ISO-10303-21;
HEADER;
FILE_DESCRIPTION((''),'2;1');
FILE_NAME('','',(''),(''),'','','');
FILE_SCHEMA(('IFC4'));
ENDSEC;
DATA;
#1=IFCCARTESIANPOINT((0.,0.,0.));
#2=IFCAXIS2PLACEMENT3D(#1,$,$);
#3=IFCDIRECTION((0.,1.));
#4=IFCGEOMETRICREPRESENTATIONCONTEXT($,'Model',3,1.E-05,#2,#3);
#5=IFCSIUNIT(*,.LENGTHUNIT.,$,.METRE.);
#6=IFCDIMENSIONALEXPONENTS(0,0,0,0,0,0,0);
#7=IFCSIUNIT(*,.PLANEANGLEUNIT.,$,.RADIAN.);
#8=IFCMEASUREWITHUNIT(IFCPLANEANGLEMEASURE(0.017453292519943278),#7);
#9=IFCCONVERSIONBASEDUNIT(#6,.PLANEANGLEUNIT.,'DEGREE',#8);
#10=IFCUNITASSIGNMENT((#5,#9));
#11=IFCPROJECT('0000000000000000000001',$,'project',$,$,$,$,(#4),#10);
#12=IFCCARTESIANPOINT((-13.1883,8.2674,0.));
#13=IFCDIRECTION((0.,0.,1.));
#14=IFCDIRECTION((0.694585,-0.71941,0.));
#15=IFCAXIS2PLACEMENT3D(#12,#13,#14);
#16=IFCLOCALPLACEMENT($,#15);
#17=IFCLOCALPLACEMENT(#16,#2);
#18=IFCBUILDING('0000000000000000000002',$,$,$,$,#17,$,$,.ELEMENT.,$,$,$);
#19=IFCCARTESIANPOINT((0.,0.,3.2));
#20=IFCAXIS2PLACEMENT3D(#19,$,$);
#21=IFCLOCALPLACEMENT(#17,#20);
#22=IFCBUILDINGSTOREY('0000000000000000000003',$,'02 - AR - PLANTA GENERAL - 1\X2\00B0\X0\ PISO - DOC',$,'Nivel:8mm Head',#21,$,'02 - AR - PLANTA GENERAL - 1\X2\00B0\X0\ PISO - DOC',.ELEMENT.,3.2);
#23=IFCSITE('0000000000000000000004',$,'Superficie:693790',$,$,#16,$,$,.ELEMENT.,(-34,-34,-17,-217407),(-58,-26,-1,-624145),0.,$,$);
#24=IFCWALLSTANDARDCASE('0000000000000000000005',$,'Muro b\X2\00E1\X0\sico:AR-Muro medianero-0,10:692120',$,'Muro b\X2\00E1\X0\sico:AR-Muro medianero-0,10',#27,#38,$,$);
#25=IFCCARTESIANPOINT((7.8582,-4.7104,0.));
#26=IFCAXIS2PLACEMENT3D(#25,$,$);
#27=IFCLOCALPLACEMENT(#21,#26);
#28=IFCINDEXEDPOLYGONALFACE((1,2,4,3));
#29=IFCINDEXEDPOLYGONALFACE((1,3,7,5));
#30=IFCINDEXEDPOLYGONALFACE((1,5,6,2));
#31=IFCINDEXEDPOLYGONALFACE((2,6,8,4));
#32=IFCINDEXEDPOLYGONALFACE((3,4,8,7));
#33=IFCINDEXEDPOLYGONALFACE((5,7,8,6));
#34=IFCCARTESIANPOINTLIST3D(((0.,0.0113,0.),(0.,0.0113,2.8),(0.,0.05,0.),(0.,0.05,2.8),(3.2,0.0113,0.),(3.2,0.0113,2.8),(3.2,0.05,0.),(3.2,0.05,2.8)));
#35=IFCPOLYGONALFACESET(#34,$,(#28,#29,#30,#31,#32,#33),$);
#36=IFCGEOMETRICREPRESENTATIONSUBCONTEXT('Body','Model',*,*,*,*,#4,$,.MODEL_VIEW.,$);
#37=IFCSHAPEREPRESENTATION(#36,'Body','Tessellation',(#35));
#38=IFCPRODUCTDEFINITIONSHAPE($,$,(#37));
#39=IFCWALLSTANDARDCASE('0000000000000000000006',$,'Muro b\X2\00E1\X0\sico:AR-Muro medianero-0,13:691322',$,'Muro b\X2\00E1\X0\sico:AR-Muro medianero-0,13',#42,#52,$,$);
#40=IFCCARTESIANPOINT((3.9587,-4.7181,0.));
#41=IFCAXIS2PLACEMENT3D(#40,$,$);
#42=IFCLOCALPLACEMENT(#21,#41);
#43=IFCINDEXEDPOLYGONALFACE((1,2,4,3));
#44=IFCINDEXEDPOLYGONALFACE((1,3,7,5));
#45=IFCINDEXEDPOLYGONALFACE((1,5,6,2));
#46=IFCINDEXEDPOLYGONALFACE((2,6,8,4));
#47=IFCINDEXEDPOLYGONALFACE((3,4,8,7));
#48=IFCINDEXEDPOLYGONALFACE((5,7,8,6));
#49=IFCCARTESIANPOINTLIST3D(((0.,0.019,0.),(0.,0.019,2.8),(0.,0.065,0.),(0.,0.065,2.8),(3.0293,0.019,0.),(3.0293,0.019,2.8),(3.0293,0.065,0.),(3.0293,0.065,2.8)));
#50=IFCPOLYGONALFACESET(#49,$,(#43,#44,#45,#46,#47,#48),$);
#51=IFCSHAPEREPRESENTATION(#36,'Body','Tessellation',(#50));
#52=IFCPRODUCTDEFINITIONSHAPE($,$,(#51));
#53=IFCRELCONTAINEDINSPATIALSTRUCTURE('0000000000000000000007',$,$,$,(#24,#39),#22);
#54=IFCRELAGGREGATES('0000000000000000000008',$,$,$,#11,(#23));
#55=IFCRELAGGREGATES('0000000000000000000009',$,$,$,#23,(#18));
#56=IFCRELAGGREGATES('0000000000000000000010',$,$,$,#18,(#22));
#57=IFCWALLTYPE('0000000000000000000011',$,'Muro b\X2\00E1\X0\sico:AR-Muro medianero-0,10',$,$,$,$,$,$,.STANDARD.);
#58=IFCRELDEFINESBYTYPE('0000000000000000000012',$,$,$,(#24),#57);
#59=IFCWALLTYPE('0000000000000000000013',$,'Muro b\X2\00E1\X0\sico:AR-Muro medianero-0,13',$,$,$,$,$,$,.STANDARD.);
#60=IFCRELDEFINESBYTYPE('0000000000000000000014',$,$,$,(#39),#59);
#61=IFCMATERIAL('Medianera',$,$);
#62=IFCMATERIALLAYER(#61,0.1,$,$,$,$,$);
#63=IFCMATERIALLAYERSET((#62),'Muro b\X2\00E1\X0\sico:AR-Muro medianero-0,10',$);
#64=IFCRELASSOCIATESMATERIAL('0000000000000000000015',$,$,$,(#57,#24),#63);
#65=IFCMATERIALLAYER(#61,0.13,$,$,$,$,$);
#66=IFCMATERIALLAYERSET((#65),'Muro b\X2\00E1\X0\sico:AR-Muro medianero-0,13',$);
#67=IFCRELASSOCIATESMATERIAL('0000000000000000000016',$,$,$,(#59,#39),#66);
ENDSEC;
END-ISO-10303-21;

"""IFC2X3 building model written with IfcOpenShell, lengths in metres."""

from ifc_helpers import new_model, entity, si_unit, converted_unit, direction, frame, frame_2d, origin, place, context, subcontext, project, spatial, polyline, rectangle, extrude, clip, bounded_halfspace, material, layer, layer_set, layer_usage, type_object, element, save


model = new_model("IFC2X3")

# Units and contexts
model_context = context("Model", 3, precision=1e-05, world=origin(), true_north=direction((0.0, 1.0)))
body_context = subcontext(model_context, "Body", "Model", "MODEL_VIEW")
ifc_project = project(units=[si_unit("LENGTHUNIT", "METRE"), converted_unit("PLANEANGLEUNIT", "DEGREE", entity("IfcPlaneAngleMeasure", 0.017453292519943278), si_unit("PLANEANGLEUNIT", "RADIAN"), dimensions=[0, 0, 0, 0, 0, 0, 0])], contexts=[model_context])

# Site, building, storey
site_placement = place(None, frame((-13.1883, 8.2674, 0.0), z_axis=(0.0, 0.0, 1.0), x_axis=(0.694585, -0.71941, 0.0)))
site = spatial("IfcSite", under=ifc_project, at=site_placement, Name="Superficie:693790", CompositionType="ELEMENT", RefLatitude=(-34, -34, -17, -217407), RefLongitude=(-58, -26, -1, -624145), RefElevation=0.0)
building_placement = place(site_placement, origin())
building = spatial("IfcBuilding", under=site, at=building_placement, CompositionType="ELEMENT")
storey_placement = place(building_placement, frame((0.0, 0.0, 3.2)))
storey = spatial("IfcBuildingStorey", under=building, at=storey_placement, Name="02 - AR - PLANTA GENERAL - 1° PISO - DOC", ObjectType="Nivel:8mm Head", LongName="02 - AR - PLANTA GENERAL - 1° PISO - DOC", CompositionType="ELEMENT", Elevation=3.2)

# Walls
ifc_material_1 = material(Name="Medianera")
ifc_layer_1 = layer(ifc_material_1, 0.1)
ifc_layer_set_1 = layer_set([ifc_layer_1], Name="Muro básico:AR-Muro medianero-0,10")
ifc_layer_usage_1 = layer_usage(ifc_layer_set_1, "AXIS2", "NEGATIVE", 0.05)
wall_type_1 = type_object("IfcWallType", Name="Muro básico:AR-Muro medianero-0,10", PredefinedType="STANDARD", material=ifc_layer_set_1)
wall_1_placement = place(storey_placement, frame((7.8582, -4.7104, 0.0)))
element("IfcWallStandardCase", 1, at=wall_1_placement, inside=storey, type_object=wall_type_1, material=ifc_layer_usage_1, Name="Muro básico:AR-Muro medianero-0,10:692120", ObjectType="Muro básico:AR-Muro medianero-0,10", context=body_context, shape_type="Clipping", body=[
    clip(extrude(rectangle(XDim=3.2, YDim=0.1, at=frame_2d((1.6, 0.0), x_axis=(-1.0, 0.0))), origin(), (0.0, 0.0, 1.0), 2.8), bounded_halfspace(frame((0.0, 0.0113, 0.0), z_axis=(0.0, 1.0, 0.0), x_axis=(-1.0, 0.0, 0.0)), True, frame((0.0, 0.0113, 0.0), z_axis=(0.0, 1.0, 0.0), x_axis=(-1.0, 0.0, 0.0)), polyline([(0.0, 0.0), (0.0, 2.8), (-3.2, 2.8), (-3.2, 0.0), (0.0, 0.0)]))),
])
ifc_layer_2 = layer(ifc_material_1, 0.13)
ifc_layer_set_2 = layer_set([ifc_layer_2], Name="Muro básico:AR-Muro medianero-0,13")
ifc_layer_usage_2 = layer_usage(ifc_layer_set_2, "AXIS2", "NEGATIVE", 0.065)
wall_type_2 = type_object("IfcWallType", Name="Muro básico:AR-Muro medianero-0,13", PredefinedType="STANDARD", material=ifc_layer_set_2)
wall_2_placement = place(storey_placement, frame((3.9587, -4.7181, 0.0)))
element("IfcWallStandardCase", 2, at=wall_2_placement, inside=storey, type_object=wall_type_2, material=ifc_layer_usage_2, Name="Muro básico:AR-Muro medianero-0,13:691322", ObjectType="Muro básico:AR-Muro medianero-0,13", context=body_context, shape_type="Clipping", body=[
    clip(extrude(rectangle(XDim=3.0293, YDim=0.13, at=frame_2d((1.5146, 0.0), x_axis=(-1.0, 0.0))), origin(), (0.0, 0.0, 1.0), 2.8), bounded_halfspace(frame((0.0, 0.019, 0.0), z_axis=(0.0, 1.0, 0.0), x_axis=(-1.0, 0.0, 0.0)), True, frame((0.0, 0.019, 0.0), z_axis=(0.0, 1.0, 0.0), x_axis=(-1.0, 0.0, 0.0)), polyline([(0.0, 0.0), (0.0, 2.8), (-3.0293, 2.8), (-3.0293, 0.0), (0.0, 0.0)]))),
])

save(model, "model.ifc")
